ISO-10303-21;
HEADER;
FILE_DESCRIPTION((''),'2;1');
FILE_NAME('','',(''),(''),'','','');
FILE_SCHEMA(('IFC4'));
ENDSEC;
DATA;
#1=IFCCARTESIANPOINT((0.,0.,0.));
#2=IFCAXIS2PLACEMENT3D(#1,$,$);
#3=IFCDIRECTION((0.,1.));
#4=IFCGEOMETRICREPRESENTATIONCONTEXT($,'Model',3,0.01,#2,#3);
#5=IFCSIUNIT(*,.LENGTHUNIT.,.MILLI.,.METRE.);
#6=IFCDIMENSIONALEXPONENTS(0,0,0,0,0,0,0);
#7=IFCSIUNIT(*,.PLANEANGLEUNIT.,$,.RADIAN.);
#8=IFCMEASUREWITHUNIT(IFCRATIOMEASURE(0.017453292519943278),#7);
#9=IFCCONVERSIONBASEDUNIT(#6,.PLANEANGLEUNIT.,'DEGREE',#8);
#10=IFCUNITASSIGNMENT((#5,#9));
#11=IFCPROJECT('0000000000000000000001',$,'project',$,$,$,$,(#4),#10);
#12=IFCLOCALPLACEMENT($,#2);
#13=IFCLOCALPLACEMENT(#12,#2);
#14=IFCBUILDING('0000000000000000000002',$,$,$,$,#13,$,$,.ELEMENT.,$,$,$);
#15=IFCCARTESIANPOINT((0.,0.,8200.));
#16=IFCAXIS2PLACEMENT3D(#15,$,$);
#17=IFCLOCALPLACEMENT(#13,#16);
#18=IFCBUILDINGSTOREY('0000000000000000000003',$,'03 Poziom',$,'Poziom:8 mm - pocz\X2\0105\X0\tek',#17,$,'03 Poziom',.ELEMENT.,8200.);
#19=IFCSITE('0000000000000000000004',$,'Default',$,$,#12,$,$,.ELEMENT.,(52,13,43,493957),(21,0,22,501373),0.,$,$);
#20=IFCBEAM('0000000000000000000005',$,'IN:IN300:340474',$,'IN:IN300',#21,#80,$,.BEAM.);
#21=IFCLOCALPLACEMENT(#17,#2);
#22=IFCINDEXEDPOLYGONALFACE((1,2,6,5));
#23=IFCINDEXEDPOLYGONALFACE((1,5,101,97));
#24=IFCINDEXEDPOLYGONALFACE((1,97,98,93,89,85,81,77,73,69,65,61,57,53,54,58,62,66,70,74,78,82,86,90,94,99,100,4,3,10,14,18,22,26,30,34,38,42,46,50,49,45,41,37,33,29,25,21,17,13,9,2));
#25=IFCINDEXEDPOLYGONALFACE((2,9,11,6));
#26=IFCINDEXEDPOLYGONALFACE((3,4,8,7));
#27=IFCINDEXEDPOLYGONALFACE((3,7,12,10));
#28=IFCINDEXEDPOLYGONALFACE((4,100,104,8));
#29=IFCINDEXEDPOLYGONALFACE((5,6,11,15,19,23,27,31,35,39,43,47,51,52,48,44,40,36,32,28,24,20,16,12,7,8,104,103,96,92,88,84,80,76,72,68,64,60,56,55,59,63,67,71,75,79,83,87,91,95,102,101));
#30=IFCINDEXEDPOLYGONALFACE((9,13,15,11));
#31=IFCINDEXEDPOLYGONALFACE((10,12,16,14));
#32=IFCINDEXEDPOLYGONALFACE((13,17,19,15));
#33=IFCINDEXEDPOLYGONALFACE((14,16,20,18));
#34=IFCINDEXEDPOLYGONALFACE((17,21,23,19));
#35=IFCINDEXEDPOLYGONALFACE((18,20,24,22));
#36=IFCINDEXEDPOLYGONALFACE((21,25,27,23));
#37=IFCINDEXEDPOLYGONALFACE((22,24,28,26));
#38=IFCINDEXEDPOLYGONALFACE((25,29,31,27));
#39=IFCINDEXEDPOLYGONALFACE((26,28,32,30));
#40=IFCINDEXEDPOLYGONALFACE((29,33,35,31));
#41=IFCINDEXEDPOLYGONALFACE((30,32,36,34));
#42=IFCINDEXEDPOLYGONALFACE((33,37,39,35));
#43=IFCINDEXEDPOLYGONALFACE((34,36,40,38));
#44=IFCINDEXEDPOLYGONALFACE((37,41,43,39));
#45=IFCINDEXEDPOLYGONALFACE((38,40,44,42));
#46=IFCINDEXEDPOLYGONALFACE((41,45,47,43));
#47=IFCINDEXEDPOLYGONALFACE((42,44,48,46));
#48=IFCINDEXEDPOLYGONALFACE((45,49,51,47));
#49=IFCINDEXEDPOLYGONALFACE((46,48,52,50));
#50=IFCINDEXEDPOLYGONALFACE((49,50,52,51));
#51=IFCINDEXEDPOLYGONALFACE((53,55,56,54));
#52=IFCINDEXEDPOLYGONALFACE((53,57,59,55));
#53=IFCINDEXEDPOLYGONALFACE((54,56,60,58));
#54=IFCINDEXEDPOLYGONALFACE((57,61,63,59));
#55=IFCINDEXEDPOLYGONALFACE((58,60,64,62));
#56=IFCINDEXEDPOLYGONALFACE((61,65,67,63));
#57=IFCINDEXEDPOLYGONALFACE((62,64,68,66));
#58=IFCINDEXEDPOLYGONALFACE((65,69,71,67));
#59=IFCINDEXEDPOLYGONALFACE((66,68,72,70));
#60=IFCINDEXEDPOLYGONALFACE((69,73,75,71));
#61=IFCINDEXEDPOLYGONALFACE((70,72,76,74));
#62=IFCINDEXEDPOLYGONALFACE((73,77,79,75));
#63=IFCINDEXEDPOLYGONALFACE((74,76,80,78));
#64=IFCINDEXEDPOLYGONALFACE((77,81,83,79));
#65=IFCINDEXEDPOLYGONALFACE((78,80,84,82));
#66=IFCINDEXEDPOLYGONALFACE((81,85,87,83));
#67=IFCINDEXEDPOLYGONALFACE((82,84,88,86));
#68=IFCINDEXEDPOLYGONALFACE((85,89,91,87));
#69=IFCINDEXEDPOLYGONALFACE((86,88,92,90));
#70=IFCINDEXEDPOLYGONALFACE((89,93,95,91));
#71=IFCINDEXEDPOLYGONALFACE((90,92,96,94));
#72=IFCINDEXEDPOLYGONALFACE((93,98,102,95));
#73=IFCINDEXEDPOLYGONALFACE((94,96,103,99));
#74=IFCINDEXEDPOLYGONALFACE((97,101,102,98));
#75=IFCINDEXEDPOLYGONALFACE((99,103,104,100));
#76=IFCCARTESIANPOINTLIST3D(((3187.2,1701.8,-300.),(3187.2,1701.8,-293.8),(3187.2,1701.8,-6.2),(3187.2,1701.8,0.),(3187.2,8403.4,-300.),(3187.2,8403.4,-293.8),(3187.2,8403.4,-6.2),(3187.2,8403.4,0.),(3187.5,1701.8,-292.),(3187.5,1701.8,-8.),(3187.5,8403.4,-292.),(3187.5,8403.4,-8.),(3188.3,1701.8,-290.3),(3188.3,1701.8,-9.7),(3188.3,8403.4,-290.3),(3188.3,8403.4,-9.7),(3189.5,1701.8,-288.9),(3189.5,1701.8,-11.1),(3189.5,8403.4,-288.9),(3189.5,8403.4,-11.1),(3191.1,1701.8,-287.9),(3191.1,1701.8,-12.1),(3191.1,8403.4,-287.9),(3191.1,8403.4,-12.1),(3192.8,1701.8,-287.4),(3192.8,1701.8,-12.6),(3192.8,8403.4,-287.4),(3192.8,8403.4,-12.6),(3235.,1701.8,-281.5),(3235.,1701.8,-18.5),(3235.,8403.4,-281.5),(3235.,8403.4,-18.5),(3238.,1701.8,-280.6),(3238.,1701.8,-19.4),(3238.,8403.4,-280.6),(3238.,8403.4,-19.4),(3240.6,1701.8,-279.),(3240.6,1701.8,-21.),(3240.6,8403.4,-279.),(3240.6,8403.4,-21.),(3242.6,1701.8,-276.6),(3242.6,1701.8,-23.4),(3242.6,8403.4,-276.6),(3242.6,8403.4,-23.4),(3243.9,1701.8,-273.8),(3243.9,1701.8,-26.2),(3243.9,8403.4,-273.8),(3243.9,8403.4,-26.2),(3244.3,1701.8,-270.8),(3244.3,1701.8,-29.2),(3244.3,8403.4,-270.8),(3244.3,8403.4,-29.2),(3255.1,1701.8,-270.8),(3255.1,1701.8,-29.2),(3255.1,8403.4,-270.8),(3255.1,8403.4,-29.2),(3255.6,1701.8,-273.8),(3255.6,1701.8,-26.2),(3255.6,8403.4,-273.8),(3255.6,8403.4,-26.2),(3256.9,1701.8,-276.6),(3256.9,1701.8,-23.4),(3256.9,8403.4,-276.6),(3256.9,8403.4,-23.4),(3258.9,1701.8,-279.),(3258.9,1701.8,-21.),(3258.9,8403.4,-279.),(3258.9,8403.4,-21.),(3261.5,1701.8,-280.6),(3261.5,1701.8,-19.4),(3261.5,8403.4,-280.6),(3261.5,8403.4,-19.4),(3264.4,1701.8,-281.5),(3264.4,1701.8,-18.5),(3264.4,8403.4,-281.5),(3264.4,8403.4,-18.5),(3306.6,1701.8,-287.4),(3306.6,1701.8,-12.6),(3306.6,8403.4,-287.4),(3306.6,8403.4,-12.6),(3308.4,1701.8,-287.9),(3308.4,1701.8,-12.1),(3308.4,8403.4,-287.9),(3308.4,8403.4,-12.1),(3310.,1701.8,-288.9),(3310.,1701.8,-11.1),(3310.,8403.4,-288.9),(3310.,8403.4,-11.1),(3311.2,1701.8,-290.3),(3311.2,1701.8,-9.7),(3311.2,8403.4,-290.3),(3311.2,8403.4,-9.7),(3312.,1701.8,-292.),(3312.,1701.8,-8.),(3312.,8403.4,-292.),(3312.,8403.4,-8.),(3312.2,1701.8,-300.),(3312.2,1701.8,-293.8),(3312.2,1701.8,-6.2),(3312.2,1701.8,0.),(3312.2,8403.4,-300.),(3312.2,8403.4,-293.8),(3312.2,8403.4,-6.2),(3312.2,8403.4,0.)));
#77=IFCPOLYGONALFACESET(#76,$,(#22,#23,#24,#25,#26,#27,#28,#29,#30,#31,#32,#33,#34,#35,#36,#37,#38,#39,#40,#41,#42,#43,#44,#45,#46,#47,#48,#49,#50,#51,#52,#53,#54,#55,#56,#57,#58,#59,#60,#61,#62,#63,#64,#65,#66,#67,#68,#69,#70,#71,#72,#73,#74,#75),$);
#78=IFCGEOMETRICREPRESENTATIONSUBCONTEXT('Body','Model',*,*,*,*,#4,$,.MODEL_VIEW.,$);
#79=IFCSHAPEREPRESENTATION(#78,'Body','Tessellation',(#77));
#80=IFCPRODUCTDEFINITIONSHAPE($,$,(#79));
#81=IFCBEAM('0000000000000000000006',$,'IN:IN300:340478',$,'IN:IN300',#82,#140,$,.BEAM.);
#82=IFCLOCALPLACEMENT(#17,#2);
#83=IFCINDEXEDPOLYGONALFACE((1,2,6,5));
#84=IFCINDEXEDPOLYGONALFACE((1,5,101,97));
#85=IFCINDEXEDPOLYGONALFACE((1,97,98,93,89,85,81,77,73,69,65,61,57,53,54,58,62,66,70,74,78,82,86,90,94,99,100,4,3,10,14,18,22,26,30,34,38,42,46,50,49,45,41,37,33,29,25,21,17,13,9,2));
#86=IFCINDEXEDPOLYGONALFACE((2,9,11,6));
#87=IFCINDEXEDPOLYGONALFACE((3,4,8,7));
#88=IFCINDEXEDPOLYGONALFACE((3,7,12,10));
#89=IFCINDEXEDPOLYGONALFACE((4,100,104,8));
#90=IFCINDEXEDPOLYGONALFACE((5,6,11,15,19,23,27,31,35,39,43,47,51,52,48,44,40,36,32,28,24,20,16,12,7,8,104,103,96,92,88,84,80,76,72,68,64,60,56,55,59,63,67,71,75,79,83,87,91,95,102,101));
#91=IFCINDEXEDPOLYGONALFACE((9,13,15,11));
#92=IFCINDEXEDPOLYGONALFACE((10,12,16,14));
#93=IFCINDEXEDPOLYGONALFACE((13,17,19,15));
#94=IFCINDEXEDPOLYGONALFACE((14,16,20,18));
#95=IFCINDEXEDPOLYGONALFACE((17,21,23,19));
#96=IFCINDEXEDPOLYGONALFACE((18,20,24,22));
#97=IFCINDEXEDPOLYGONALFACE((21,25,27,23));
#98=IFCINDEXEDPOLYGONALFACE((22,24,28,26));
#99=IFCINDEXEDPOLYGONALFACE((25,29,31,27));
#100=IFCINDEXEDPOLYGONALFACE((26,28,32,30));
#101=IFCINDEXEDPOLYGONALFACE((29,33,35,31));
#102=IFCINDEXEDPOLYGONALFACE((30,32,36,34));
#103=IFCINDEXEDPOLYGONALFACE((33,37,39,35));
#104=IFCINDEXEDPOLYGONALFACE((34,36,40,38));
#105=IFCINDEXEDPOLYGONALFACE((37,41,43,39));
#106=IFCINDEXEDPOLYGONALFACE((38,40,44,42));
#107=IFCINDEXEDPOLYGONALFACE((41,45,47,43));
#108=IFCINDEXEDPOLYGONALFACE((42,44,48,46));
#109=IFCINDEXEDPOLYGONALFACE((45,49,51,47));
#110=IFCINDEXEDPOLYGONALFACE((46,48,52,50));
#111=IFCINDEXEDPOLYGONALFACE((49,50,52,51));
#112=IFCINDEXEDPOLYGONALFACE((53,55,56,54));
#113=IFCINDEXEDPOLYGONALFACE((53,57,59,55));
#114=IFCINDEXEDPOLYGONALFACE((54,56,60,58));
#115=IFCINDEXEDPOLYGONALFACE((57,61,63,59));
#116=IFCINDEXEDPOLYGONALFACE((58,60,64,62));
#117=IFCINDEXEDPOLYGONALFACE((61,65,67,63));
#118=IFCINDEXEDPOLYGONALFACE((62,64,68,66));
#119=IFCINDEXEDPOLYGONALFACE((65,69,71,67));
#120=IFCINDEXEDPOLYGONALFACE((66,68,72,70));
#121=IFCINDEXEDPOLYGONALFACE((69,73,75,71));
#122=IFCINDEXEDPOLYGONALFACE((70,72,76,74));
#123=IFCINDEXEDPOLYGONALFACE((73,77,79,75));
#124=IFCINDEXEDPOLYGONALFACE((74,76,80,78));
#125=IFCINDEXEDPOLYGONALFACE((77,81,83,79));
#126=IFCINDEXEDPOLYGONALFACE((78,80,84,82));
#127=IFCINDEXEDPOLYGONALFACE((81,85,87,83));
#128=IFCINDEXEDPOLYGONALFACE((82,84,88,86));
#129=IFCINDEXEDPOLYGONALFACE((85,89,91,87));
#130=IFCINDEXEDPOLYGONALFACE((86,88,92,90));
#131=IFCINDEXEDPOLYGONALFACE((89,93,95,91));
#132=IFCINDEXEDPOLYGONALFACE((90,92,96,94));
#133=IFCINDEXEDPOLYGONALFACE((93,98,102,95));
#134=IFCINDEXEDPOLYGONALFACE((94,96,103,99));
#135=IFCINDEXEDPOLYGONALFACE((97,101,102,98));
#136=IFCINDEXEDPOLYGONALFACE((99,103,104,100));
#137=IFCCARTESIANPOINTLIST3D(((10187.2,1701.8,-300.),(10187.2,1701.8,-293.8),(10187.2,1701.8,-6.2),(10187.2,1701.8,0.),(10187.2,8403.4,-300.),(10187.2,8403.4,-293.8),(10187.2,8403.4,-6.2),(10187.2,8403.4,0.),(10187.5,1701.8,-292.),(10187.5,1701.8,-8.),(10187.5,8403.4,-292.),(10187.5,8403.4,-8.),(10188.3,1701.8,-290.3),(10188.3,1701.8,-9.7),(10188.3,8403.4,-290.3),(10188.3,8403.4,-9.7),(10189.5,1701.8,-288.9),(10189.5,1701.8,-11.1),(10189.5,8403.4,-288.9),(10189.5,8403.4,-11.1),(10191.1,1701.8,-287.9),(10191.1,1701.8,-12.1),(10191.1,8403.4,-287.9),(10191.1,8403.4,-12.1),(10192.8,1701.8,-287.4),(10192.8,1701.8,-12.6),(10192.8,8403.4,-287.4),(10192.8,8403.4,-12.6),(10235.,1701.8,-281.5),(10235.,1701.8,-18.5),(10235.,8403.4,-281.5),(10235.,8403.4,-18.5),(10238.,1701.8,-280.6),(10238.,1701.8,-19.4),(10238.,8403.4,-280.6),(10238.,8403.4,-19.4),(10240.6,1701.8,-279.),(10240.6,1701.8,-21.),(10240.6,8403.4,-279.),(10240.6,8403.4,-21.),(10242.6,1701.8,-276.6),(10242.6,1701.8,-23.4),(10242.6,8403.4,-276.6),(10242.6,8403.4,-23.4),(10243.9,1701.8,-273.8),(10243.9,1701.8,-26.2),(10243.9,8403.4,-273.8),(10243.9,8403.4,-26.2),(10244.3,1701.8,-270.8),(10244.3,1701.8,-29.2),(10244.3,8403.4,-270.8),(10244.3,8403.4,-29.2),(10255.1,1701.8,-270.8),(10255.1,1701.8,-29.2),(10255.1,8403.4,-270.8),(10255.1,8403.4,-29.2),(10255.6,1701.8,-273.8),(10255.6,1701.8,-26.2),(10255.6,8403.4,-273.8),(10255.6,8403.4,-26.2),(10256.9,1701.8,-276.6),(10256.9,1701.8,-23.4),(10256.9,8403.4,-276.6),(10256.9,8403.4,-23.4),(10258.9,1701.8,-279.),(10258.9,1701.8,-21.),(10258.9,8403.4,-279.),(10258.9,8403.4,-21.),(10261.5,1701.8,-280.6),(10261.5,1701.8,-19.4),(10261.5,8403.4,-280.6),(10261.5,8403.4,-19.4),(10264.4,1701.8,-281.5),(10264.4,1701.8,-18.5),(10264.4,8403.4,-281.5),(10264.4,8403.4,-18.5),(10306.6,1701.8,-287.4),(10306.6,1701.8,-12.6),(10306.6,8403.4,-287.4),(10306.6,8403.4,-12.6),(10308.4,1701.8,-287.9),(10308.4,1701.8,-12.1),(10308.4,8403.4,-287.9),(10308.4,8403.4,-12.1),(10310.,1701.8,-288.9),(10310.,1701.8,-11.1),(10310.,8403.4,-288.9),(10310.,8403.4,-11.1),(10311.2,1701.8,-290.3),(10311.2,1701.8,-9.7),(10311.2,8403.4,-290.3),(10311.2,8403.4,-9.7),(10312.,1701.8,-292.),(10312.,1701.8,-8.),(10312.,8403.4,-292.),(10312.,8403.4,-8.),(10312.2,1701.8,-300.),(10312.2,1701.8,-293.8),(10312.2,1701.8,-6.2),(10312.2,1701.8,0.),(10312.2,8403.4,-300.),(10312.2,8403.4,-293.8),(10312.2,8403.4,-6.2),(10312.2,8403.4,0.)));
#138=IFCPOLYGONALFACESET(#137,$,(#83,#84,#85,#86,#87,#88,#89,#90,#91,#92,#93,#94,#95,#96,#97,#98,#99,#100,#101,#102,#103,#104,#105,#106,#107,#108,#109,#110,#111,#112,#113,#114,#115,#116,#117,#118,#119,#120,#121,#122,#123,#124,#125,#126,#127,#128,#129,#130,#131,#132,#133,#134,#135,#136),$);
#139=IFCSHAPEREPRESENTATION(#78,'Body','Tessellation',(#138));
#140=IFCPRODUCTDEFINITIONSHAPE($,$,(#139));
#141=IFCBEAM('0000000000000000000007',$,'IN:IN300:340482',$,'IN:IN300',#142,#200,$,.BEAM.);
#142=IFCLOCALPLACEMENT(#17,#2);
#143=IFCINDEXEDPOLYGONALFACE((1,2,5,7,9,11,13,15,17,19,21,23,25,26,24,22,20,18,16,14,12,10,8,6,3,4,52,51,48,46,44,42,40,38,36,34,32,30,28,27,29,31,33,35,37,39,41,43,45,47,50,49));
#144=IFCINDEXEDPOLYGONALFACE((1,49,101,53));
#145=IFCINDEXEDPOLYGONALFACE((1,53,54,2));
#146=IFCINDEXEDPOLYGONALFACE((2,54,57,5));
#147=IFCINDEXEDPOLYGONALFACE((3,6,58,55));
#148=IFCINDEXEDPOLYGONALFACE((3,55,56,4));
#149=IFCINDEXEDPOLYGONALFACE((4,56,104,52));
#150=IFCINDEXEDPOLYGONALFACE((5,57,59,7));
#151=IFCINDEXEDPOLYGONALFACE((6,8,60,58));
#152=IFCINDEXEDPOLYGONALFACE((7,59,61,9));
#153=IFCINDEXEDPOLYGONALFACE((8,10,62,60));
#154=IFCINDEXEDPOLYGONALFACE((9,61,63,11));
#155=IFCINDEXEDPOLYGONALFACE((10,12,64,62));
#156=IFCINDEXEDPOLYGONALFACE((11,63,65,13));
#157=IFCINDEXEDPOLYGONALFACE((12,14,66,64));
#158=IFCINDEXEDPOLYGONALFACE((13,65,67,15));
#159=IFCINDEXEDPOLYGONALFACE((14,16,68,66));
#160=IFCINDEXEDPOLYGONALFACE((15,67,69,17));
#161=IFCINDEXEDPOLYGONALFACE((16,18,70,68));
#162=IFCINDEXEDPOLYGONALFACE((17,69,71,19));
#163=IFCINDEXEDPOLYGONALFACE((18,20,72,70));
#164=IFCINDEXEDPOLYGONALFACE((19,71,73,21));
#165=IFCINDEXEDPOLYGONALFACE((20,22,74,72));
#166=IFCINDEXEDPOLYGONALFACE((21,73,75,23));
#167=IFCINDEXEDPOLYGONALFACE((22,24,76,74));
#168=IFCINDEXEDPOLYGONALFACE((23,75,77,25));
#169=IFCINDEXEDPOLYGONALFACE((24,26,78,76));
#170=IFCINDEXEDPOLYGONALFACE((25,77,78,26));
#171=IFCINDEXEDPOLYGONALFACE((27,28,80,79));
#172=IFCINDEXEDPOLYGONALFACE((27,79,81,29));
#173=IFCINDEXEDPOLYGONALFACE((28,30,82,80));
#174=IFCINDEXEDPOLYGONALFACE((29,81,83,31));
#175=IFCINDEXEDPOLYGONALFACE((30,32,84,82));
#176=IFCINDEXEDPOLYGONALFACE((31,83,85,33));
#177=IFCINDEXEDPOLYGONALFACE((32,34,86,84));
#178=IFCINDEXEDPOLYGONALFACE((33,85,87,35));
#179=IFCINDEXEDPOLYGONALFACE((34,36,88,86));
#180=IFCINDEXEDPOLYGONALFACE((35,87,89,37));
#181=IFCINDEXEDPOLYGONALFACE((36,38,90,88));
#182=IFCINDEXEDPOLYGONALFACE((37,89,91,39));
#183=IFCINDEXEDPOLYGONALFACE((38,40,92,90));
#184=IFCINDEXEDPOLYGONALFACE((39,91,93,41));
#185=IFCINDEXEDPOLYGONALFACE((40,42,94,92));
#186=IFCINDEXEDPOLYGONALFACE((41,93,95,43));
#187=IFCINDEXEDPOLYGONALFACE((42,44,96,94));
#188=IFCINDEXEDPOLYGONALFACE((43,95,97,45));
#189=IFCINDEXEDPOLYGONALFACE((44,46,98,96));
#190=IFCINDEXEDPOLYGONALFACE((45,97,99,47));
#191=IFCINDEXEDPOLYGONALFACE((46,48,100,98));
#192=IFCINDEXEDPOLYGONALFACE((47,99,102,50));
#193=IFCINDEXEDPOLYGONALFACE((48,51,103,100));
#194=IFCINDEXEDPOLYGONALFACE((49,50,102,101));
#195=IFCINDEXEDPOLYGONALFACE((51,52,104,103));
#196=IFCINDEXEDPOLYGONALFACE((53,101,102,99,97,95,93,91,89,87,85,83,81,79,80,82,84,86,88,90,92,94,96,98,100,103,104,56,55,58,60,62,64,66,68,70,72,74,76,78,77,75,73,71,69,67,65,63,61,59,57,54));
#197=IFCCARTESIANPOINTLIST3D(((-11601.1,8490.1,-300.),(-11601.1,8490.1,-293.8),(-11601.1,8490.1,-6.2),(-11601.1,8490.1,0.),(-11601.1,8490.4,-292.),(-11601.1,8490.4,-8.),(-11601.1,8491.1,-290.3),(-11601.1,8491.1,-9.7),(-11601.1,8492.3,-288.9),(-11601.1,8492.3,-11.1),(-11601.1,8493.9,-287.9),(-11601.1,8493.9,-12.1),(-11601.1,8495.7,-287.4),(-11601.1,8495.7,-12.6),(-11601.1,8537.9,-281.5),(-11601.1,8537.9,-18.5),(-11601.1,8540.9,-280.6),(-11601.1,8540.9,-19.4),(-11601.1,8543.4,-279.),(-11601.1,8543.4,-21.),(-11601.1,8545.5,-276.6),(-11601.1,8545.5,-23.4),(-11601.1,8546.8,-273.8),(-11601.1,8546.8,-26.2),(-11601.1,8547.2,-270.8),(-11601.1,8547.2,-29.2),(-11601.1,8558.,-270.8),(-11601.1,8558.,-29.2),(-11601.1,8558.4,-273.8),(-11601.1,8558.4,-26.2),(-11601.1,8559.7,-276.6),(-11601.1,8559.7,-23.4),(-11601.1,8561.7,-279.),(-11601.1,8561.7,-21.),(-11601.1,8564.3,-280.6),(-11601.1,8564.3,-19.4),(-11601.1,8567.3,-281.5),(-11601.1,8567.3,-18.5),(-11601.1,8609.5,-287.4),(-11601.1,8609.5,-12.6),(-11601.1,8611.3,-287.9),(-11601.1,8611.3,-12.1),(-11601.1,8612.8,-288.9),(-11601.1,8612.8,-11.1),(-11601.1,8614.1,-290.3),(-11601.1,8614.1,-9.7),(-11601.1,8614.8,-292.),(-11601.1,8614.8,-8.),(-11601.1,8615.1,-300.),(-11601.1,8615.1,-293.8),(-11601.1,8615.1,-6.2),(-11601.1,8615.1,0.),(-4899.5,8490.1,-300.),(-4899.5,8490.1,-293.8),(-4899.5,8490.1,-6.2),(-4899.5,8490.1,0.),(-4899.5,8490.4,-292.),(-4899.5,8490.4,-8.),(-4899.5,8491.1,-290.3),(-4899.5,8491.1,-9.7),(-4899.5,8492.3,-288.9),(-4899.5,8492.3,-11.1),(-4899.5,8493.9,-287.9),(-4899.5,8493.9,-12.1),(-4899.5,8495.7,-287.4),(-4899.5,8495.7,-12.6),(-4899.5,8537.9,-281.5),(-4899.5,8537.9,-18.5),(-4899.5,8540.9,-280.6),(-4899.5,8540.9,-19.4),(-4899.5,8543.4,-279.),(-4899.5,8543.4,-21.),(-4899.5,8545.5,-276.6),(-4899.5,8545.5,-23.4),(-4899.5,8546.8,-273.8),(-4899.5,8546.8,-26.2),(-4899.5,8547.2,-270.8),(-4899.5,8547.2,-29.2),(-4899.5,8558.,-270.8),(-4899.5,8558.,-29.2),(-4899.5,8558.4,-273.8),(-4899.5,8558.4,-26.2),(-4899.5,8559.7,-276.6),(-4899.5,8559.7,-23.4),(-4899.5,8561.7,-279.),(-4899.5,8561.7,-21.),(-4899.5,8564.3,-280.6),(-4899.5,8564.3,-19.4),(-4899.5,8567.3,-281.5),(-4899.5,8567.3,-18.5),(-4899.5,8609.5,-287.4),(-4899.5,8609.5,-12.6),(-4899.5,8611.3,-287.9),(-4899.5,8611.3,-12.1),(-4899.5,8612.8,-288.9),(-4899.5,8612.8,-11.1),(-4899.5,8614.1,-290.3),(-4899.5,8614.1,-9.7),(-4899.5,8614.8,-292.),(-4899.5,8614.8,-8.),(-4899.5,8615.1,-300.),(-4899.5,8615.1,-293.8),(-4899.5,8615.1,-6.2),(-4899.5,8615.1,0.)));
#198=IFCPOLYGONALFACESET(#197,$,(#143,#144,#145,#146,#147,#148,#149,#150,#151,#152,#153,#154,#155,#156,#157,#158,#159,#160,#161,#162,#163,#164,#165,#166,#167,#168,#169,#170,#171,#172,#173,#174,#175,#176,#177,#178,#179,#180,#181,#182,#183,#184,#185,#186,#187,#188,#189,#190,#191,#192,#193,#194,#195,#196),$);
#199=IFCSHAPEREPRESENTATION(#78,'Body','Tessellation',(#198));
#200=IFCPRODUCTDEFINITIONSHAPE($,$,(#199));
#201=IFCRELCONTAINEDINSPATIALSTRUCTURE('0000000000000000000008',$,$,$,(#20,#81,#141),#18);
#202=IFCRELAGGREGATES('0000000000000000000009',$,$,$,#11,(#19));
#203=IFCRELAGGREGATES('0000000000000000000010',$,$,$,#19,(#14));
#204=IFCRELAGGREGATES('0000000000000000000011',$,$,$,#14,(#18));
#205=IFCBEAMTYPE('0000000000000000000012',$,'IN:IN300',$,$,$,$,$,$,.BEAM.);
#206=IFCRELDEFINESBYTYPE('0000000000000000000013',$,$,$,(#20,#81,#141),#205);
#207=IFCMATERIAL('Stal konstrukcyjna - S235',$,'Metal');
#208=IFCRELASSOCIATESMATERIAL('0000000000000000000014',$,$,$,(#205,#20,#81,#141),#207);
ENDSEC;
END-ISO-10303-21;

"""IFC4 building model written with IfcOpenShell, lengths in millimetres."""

from ifc_helpers import new_model, entity, si_unit, converted_unit, direction, frame, origin, place, context, subcontext, project, spatial, line, arc, indexed_curve, outline, extrude, source, transform, mapped, material, type_object, type_shapes, element, save


model = new_model("IFC4")

# Units and contexts
model_context = context("Model", 3, precision=0.01, world=origin(), true_north=direction((0.0, 1.0)))
body_context = subcontext(model_context, "Body", "Model", "MODEL_VIEW")
ifc_project = project(units=[si_unit("LENGTHUNIT", "METRE", prefix="MILLI"), converted_unit("PLANEANGLEUNIT", "DEGREE", entity("IfcRatioMeasure", 0.017453292519943278), si_unit("PLANEANGLEUNIT", "RADIAN"), dimensions=[0, 0, 0, 0, 0, 0, 0])], contexts=[model_context])

# Site, building, storey
site_placement = place(None, origin())
site = spatial("IfcSite", under=ifc_project, at=site_placement, Name="Default", CompositionType="ELEMENT", RefLatitude=(52, 13, 43, 493957), RefLongitude=(21, 0, 22, 501373), RefElevation=0.0)
building_placement = place(site_placement, origin())
building = spatial("IfcBuilding", under=site, at=building_placement, CompositionType="ELEMENT")
storey_placement = place(building_placement, frame((0.0, 0.0, 8200.0)))
storey = spatial("IfcBuildingStorey", under=building, at=storey_placement, Name="03 Poziom", ObjectType="Poziom:8 mm - początek", LongName="03 Poziom", CompositionType="ELEMENT", Elevation=8200.0)

# Shared definitions
ifc_material_1 = material(Name="Stal konstrukcyjna - S235", Category="Metal")

# Beams
beam_type_1 = type_object("IfcBeamType", Name="IN:IN300", PredefinedType="BEAM", material=ifc_material_1)
shared_shape_1 = source(origin(), body_context, "Body", "SweptSolid", [
    extrude(outline(indexed_curve([(143.8, -62.5), (150.0, -62.5), (150.0, 62.5), (143.8, 62.5), (139.6, 60.9), (137.4, 56.9), (131.5, 14.7), (127.9, 8.1), (120.8, 5.4), (-120.8, 5.4), (-127.9, 8.1), (-131.5, 14.7), (-137.4, 56.9), (-139.6, 60.9), (-143.8, 62.5), (-150.0, 62.5), (-150.0, -62.5), (-143.8, -62.5), (-139.6, -60.9), (-137.4, -56.9), (-131.5, -14.7), (-127.9, -8.1), (-120.8, -5.4), (120.8, -5.4), (127.9, -8.1), (131.5, -14.7), (137.4, -56.9), (139.6, -60.9)], segments=[line(1, 2, 3, 4), arc(4, 5, 6), line(6, 7), arc(7, 8, 9), line(9, 10), arc(10, 11, 12), line(12, 13), arc(13, 14, 15), line(15, 16, 17, 18), arc(18, 19, 20), line(20, 21), arc(21, 22, 23), line(23, 24), arc(24, 25, 26), line(26, 27), arc(27, 28, 1)], self_intersect=False)), frame((-3350.8, 0.0, 0.0), z_axis=(1.0, 0.0, 0.0), x_axis=(0.0, 0.0, -1.0)), (0.0, 0.0, 1.0), 6701.6),
])
type_shapes(beam_type_1, [shared_shape_1])
for number, where, z_axis, x_axis, name in (
    (1, (3249.7, 5052.6, -150.0), (0.0, 0.0, 1.0), (0.0, -1.0, 0.0), "IN:IN300:340474"),
    (2, (10249.7, 5052.6, -150.0), (0.0, 0.0, 1.0), (0.0, -1.0, 0.0), "IN:IN300:340478"),
):
    element("IfcBeam", number, at=place(storey_placement, frame(where, z_axis=z_axis, x_axis=x_axis)), inside=storey, type_object=beam_type_1, material=ifc_material_1, Name=name, ObjectType="IN:IN300", PredefinedType="BEAM", context=body_context, shape_type="MappedRepresentation", body=[
        mapped(shared_shape_1, transform((0.0, 0.0, 0.0), scale=1.0)),
    ])
for number, where, name in (
    (3, (-8250.3, 8552.6, -150.0), "IN:IN300:340482"),
):
    element("IfcBeam", number, at=place(storey_placement, frame(where)), inside=storey, type_object=beam_type_1, material=ifc_material_1, Name=name, ObjectType="IN:IN300", PredefinedType="BEAM", context=body_context, shape_type="MappedRepresentation", body=[
        mapped(shared_shape_1, transform((0.0, 0.0, 0.0), scale=1.0)),
    ])

save(model, "model.ifc")
